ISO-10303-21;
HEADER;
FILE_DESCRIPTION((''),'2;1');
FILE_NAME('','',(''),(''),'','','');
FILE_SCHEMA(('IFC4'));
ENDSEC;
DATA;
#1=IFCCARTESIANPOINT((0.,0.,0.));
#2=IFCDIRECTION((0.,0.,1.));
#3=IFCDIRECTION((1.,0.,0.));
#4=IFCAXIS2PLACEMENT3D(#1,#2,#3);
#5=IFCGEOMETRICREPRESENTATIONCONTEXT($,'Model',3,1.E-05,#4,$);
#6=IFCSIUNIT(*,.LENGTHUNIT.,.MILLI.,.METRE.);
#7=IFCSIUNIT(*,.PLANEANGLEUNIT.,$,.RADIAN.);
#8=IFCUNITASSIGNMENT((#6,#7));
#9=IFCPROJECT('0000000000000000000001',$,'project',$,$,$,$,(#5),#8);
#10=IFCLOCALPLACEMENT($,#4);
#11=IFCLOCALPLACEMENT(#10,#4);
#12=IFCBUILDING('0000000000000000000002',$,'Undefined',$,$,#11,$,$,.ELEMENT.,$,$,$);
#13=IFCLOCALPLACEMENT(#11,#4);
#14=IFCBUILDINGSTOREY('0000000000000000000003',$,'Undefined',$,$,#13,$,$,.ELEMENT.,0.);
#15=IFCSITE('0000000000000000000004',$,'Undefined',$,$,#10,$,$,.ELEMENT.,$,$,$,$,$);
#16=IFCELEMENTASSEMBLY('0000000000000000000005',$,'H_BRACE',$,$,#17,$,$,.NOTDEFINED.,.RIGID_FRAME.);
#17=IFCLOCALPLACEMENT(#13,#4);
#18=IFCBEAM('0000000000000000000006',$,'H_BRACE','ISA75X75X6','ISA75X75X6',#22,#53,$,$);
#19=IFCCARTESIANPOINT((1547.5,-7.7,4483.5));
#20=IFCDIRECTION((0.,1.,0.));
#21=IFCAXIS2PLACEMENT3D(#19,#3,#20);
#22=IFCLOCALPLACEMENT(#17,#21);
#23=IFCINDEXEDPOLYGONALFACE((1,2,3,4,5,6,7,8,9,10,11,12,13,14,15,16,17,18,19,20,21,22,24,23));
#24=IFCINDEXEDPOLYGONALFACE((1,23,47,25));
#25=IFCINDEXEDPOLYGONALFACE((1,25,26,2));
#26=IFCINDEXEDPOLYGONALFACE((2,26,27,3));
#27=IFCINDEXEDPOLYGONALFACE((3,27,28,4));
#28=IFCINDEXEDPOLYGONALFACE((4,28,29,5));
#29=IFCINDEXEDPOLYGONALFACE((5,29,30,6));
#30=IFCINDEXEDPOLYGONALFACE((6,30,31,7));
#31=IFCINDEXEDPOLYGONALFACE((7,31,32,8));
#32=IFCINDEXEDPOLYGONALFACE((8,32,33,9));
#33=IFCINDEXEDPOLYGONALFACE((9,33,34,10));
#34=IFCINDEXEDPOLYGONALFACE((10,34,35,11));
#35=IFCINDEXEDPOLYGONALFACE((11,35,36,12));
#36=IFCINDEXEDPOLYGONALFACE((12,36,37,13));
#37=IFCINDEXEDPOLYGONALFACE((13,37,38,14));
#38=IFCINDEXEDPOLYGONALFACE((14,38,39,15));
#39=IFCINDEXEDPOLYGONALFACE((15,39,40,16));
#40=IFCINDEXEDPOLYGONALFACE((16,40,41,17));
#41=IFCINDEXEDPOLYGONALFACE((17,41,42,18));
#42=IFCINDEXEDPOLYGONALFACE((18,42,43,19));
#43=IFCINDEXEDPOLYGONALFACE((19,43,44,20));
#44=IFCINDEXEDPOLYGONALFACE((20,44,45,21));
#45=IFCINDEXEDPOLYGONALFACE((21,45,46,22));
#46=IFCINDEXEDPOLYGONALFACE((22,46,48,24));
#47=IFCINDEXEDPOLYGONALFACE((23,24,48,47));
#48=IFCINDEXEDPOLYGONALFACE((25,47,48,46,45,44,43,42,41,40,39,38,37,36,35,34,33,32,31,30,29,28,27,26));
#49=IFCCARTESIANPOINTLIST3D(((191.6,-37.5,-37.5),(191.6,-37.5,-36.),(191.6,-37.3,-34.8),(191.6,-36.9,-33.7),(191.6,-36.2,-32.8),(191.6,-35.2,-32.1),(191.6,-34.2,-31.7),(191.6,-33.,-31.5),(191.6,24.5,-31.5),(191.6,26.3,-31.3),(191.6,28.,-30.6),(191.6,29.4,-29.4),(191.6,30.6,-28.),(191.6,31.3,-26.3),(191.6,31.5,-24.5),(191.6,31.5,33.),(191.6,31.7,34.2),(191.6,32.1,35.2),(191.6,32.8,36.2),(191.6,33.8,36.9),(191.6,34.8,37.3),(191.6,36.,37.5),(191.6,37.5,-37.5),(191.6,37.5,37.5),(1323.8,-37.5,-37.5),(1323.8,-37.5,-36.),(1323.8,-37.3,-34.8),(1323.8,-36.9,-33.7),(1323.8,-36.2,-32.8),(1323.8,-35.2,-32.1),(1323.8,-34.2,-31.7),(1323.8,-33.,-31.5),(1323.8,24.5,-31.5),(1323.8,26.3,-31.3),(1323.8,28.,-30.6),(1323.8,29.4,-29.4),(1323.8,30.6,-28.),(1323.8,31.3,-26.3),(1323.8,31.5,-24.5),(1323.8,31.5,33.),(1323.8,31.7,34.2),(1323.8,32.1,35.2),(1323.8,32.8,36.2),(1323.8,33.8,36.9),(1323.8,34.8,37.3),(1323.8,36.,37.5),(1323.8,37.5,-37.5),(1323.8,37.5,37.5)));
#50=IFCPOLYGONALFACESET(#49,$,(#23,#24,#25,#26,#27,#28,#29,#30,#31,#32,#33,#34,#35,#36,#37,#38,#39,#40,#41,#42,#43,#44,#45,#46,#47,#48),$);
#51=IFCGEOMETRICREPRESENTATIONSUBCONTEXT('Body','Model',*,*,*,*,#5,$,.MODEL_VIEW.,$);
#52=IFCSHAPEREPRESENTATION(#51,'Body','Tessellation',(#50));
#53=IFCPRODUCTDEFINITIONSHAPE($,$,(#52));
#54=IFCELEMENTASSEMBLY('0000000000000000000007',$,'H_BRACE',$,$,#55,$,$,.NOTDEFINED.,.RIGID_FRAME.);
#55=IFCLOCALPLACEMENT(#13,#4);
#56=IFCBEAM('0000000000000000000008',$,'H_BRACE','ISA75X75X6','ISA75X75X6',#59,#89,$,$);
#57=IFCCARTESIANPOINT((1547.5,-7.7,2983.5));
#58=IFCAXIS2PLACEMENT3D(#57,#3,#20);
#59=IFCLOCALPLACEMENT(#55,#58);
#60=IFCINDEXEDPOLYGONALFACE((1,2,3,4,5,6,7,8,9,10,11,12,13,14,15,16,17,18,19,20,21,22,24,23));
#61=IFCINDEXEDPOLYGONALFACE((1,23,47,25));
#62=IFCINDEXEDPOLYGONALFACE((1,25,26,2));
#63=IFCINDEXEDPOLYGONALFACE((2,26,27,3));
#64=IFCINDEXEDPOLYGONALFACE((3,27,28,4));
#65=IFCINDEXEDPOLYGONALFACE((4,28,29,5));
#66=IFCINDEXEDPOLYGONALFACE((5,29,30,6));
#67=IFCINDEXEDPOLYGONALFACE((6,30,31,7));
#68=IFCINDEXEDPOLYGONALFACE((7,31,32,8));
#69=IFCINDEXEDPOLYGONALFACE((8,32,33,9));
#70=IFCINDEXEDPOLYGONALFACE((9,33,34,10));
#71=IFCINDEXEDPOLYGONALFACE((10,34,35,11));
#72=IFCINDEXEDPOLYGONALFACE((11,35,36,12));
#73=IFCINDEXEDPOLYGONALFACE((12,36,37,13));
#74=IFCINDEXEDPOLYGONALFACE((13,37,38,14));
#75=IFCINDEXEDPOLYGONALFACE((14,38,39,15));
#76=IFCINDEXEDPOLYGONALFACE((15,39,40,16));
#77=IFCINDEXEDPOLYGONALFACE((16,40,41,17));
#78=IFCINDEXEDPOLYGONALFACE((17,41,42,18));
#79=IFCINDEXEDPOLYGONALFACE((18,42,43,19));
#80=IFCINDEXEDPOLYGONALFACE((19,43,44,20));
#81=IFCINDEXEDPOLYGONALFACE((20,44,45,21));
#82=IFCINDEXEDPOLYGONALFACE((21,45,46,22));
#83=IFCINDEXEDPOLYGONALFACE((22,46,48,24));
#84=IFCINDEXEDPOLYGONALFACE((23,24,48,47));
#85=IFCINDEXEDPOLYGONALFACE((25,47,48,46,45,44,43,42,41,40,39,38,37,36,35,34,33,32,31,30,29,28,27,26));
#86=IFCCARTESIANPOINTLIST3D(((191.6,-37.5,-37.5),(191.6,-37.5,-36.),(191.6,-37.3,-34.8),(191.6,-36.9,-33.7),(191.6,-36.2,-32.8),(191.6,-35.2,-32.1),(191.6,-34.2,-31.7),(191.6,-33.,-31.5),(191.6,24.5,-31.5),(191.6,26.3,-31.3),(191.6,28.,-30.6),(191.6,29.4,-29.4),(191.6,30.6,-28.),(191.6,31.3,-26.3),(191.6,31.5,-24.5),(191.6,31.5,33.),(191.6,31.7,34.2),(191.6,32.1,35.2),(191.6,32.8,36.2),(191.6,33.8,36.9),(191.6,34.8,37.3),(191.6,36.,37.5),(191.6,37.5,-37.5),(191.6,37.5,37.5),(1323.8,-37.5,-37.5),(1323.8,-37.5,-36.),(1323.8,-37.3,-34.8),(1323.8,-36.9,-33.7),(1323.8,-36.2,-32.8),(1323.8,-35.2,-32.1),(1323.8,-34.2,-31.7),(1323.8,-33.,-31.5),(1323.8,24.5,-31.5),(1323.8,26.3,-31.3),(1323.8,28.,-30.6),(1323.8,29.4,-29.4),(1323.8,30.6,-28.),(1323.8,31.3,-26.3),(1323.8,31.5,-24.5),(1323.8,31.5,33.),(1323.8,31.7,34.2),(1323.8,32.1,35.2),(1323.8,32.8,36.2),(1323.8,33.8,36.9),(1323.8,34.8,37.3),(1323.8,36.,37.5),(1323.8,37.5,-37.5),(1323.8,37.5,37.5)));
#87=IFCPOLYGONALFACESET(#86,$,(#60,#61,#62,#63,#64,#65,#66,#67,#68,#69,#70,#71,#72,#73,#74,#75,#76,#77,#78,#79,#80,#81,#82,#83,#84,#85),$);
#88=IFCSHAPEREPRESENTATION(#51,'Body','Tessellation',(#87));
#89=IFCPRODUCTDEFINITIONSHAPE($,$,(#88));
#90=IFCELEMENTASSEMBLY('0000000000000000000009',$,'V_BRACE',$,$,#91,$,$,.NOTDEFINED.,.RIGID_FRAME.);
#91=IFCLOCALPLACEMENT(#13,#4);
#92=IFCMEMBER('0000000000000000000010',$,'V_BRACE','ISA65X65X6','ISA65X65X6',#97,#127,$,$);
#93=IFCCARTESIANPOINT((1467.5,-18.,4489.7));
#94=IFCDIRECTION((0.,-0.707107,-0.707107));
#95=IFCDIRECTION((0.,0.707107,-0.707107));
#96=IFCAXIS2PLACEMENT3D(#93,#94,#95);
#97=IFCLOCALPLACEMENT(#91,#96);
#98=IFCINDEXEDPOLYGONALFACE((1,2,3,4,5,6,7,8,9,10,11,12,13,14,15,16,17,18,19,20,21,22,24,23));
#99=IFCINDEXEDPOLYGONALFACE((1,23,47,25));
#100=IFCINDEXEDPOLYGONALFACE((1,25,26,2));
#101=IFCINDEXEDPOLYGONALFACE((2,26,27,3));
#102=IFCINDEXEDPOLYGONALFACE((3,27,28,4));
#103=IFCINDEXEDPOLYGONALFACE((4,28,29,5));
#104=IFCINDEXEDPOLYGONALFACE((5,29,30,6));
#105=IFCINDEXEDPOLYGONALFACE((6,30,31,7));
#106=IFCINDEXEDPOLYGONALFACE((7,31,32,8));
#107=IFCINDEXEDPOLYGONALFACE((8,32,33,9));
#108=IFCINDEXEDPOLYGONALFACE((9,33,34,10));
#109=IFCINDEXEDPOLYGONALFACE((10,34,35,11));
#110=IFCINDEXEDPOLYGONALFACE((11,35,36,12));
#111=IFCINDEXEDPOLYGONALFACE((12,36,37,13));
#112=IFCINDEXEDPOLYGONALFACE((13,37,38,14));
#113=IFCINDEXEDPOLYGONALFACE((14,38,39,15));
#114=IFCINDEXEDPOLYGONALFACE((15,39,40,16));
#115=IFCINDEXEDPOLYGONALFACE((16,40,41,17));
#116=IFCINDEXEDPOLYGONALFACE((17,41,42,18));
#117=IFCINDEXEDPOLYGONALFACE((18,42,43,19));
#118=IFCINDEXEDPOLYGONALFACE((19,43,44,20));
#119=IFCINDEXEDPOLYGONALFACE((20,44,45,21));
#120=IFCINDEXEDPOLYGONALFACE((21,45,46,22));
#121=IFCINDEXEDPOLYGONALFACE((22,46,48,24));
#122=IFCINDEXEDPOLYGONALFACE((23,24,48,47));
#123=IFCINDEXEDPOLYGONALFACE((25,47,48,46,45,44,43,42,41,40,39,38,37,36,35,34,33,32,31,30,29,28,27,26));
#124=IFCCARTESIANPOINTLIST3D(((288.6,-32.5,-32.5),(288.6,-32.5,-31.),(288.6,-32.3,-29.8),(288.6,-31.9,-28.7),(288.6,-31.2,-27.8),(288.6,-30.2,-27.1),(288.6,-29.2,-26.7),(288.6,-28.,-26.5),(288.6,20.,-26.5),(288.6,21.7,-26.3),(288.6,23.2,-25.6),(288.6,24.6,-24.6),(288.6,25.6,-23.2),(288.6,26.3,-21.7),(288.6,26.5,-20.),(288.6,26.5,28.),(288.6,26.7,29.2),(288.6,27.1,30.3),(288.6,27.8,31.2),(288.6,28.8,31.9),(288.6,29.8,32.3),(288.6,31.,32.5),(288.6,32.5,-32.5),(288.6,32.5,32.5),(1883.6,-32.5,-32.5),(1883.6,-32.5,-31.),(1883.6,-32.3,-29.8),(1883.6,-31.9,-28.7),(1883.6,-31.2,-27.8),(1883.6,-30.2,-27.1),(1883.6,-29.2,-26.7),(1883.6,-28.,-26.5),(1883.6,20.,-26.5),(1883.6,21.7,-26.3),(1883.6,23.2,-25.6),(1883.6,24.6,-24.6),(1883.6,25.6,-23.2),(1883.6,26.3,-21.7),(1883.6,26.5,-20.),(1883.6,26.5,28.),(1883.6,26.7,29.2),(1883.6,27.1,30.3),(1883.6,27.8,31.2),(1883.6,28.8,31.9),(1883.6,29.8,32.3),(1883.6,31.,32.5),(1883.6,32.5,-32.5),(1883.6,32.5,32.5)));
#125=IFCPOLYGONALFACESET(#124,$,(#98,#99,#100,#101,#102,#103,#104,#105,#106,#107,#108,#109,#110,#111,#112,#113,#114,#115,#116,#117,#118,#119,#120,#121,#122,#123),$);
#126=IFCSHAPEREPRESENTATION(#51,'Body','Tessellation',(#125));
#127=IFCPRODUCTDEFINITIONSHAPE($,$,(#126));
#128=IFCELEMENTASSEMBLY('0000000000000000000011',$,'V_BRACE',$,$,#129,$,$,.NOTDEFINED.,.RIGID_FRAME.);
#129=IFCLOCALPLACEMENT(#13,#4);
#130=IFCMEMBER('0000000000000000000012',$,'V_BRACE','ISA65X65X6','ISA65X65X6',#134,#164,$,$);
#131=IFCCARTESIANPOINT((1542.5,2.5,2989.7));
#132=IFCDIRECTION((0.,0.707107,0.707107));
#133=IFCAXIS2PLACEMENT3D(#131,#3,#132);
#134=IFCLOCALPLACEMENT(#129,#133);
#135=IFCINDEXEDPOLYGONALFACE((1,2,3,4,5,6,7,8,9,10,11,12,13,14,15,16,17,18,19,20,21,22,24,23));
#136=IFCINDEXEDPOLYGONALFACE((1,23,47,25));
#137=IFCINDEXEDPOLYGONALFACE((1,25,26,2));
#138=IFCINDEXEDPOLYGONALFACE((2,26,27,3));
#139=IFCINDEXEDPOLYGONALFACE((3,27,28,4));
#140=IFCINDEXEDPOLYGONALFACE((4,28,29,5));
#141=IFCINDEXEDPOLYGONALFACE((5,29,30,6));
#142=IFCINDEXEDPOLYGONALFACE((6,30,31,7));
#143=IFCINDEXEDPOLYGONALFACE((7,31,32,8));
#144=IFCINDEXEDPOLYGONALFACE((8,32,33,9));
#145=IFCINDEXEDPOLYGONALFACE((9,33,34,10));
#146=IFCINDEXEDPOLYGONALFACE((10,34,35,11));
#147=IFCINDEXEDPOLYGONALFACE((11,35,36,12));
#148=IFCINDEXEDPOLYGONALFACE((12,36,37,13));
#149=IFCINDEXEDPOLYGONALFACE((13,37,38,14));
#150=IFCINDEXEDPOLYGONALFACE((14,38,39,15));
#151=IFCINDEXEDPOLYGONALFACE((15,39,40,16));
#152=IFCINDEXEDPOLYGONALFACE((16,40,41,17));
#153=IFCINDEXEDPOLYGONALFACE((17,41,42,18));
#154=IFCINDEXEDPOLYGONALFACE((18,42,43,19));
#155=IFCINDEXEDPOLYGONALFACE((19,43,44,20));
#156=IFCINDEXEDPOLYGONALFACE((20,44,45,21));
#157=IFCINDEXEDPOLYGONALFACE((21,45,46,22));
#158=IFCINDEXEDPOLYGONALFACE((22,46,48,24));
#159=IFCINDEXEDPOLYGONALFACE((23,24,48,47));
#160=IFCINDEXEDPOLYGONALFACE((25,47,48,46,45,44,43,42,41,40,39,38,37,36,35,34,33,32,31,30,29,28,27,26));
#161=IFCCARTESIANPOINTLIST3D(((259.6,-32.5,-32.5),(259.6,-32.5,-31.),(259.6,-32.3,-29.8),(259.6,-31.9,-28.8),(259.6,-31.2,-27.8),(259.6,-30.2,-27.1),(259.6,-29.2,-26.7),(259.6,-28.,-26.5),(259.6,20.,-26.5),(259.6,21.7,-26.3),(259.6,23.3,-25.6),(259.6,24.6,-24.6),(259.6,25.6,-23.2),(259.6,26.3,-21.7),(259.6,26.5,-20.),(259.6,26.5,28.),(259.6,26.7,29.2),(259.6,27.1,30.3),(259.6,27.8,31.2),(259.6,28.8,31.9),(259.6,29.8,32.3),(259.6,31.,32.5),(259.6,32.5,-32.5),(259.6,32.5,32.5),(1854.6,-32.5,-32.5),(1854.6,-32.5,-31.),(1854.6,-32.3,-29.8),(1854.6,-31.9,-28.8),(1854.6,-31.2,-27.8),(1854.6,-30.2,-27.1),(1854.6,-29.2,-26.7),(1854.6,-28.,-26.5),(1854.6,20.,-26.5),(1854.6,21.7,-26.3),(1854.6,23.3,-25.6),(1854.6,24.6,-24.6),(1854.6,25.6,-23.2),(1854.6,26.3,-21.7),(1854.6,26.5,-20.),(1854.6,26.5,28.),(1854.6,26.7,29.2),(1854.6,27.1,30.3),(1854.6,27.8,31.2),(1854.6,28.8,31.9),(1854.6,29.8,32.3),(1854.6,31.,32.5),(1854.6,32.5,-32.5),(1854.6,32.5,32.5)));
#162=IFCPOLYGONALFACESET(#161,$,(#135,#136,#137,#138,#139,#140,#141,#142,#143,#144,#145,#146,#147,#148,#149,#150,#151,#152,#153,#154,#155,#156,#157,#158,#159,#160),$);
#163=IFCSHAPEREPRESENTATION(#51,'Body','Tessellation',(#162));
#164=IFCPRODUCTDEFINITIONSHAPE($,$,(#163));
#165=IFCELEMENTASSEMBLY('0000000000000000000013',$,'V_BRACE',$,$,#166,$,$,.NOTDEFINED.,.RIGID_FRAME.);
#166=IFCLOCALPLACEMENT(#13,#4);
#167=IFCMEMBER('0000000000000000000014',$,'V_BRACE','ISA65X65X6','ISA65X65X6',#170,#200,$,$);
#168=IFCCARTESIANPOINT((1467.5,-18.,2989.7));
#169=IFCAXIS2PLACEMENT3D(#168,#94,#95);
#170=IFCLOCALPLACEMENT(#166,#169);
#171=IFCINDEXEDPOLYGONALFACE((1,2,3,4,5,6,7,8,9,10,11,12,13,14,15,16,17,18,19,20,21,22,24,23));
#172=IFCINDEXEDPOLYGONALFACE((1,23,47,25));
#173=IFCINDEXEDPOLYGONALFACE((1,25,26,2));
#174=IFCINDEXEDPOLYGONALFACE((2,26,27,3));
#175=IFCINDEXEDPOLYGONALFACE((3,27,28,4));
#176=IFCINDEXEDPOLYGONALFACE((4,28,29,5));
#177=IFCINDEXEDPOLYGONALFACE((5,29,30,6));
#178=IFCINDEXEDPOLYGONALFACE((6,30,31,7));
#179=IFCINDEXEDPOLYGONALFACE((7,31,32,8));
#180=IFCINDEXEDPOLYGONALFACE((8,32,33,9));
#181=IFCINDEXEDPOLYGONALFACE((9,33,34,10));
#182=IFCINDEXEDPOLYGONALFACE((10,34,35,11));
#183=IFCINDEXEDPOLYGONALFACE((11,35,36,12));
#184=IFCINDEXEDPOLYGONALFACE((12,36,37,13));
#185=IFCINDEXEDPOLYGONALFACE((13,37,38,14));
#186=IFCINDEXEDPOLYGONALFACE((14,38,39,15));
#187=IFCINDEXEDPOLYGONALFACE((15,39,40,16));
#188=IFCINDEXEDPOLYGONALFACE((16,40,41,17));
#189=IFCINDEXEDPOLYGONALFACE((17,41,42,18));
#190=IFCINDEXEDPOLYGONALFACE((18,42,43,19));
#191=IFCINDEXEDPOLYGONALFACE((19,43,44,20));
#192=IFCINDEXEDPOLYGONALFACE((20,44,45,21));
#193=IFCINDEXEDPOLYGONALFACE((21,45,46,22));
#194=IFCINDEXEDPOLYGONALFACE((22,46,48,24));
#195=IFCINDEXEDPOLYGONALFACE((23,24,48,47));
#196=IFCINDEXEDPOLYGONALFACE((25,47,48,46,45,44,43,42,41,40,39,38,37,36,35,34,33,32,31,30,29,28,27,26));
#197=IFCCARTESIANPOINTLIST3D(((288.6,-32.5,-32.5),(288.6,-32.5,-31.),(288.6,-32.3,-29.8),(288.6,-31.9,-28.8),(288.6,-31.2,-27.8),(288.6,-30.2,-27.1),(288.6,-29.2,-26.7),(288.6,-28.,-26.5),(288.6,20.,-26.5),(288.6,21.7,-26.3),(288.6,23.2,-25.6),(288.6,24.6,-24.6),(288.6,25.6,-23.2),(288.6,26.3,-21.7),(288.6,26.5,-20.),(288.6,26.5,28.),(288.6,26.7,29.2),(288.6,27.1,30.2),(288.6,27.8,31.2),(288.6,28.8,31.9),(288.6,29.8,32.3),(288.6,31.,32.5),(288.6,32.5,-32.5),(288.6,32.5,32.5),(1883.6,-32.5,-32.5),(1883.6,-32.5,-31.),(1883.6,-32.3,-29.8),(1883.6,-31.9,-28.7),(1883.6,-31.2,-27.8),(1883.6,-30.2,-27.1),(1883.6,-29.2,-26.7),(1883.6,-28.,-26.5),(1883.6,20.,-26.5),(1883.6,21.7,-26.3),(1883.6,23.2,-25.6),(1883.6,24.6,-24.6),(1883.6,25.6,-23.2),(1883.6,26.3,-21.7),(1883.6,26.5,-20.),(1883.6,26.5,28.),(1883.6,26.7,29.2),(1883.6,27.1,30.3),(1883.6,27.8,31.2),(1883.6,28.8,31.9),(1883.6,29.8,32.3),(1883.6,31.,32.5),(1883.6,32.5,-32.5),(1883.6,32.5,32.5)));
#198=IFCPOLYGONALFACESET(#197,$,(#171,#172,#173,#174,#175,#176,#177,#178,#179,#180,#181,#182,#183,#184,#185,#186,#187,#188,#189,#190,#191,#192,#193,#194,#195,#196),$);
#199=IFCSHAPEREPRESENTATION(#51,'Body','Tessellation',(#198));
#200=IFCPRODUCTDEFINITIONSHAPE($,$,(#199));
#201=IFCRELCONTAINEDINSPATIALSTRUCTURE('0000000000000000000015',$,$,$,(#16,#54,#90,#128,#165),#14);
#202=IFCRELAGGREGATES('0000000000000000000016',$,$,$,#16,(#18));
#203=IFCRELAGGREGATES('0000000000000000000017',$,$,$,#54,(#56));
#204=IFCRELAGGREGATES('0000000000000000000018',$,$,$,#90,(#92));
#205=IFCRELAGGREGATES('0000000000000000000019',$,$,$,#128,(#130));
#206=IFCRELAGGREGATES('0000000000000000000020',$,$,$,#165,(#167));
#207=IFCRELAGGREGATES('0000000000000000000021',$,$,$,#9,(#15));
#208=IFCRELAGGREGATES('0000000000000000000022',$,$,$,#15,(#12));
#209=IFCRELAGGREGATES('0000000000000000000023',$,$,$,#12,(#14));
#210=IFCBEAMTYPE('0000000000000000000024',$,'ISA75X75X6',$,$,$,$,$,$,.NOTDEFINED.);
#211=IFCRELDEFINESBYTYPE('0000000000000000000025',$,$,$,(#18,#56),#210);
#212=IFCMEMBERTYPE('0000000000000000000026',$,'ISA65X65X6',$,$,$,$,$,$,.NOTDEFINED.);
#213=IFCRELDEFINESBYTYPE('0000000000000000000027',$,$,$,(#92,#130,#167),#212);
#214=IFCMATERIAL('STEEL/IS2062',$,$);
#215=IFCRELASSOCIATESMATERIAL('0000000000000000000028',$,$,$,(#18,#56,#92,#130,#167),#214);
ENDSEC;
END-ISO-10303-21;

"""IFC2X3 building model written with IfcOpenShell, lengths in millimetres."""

from ifc_helpers import new_model, si_unit, frame, origin_with_axes, origin_2d_with_axis, place, context, subcontext, project, spatial, l_section, extrude, clip, halfspace, material, type_object, element, aggregate, save


model = new_model("IFC2X3")

# Units and contexts
model_context = context("Model", 3, precision=1e-05, world=origin_with_axes())
body_context = subcontext(model_context, "Body", "Model", "MODEL_VIEW")
ifc_project = project(units=[si_unit("LENGTHUNIT", "METRE", prefix="MILLI"), si_unit("PLANEANGLEUNIT", "RADIAN")], contexts=[model_context])

# Site, building, storey
site_placement = place(None, origin_with_axes())
site = spatial("IfcSite", under=ifc_project, at=site_placement, Name="Undefined", CompositionType="ELEMENT")
building_placement = place(site_placement, origin_with_axes())
building = spatial("IfcBuilding", under=site, at=building_placement, Name="Undefined", CompositionType="ELEMENT")
storey_placement = place(building_placement, origin_with_axes())
storey = spatial("IfcBuildingStorey", under=building, at=storey_placement, Name="Undefined", CompositionType="ELEMENT", Elevation=0.0)

# Shared definitions
ifc_material = material(Name="STEEL/IS2062")

# Element assemblies, beams
assembly_1_placement = place(storey_placement, origin_with_axes())
assembly_1 = element("IfcElementAssembly", 1, at=assembly_1_placement, inside=storey, Name="H_BRACE", AssemblyPlace="NOTDEFINED", PredefinedType="RIGID_FRAME")
beam_type_1 = type_object("IfcBeamType", Name="ISA75X75X6", PredefinedType="NOTDEFINED")
beam_1_placement = place(assembly_1_placement, frame((1547.5, -7.7, 4483.5), z_axis=(1.0, 0.0, 0.0), x_axis=(0.0, 1.0, 0.0)))
beam_1 = element("IfcBeam", 2, at=beam_1_placement, type_object=beam_type_1, material=ifc_material, Name="H_BRACE", Description="ISA75X75X6", ObjectType="ISA75X75X6", context=body_context, shape_type="Clipping", body=[
    clip(clip(extrude(l_section(Depth=75.0, Width=75.0, Thickness=6.0, FilletRadius=7.0, EdgeRadius=4.5, at=origin_2d_with_axis()), frame((1500.0, 0.0, 0.0), z_axis=(-1.0, 0.0, 0.0), x_axis=(0.0, -1.0, 0.0)), (0.0, 0.0, 1.0), 1500.0), halfspace(frame((1323.8, 0.0, -47.5), z_axis=(-1.0, 0.0, 0.0), x_axis=(0.0, 1.0, 0.0)), True)), halfspace(frame((191.6, 0.0, -47.5), z_axis=(1.0, 0.0, 0.0), x_axis=(0.0, -1.0, 0.0)), True)),
])
aggregate(assembly_1, [beam_1])
assembly_2_placement = place(storey_placement, origin_with_axes())
assembly_2 = element("IfcElementAssembly", 3, at=assembly_2_placement, inside=storey, Name="H_BRACE", AssemblyPlace="NOTDEFINED", PredefinedType="RIGID_FRAME")
beam_2_placement = place(assembly_2_placement, frame((1547.5, -7.7, 2983.5), z_axis=(1.0, 0.0, 0.0), x_axis=(0.0, 1.0, 0.0)))
beam_2 = element("IfcBeam", 4, at=beam_2_placement, type_object=beam_type_1, material=ifc_material, Name="H_BRACE", Description="ISA75X75X6", ObjectType="ISA75X75X6", context=body_context, shape_type="Clipping", body=[
    clip(clip(extrude(l_section(Depth=75.0, Width=75.0, Thickness=6.0, FilletRadius=7.0, EdgeRadius=4.5, at=origin_2d_with_axis()), frame((1500.0, 0.0, 0.0), z_axis=(-1.0, 0.0, 0.0), x_axis=(0.0, -1.0, 0.0)), (0.0, 0.0, 1.0), 1500.0), halfspace(frame((1323.8, 0.0, -47.5), z_axis=(-1.0, 0.0, 0.0), x_axis=(0.0, 1.0, 0.0)), True)), halfspace(frame((191.6, 0.0, -47.5), z_axis=(1.0, 0.0, 0.0), x_axis=(0.0, -1.0, 0.0)), True)),
])
aggregate(assembly_2, [beam_2])

# Element assemblies, members
assembly_3_placement = place(storey_placement, origin_with_axes())
assembly_3 = element("IfcElementAssembly", 5, at=assembly_3_placement, inside=storey, Name="V_BRACE", AssemblyPlace="NOTDEFINED", PredefinedType="RIGID_FRAME")
member_type = type_object("IfcMemberType", Name="ISA65X65X6", PredefinedType="NOTDEFINED")
member_1_placement = place(assembly_3_placement, frame((1467.5, -18.0, 4489.7), z_axis=(0.0, -0.707107, -0.707107), x_axis=(0.0, 0.707107, -0.707107)))
member_1 = element("IfcMember", 6, at=member_1_placement, type_object=member_type, material=ifc_material, Name="V_BRACE", Description="ISA65X65X6", ObjectType="ISA65X65X6", context=body_context, shape_type="Clipping", body=[
    clip(clip(extrude(l_section(Depth=65.0, Width=65.0, Thickness=6.0, FilletRadius=6.5, EdgeRadius=4.5, at=origin_2d_with_axis()), frame((2121.3, 0.0, 0.0), z_axis=(-1.0, 0.0, 0.0), x_axis=(0.0, -1.0, 0.0)), (0.0, 0.0, 1.0), 2121.3), halfspace(frame((1883.6, 32.5, 0.0), z_axis=(-1.0, 0.0, 0.0), x_axis=(0.0, 0.0, -1.0)), True)), halfspace(frame((288.6, 32.5, 0.0), z_axis=(1.0, 0.0, 0.0), x_axis=(0.0, 0.0, 1.0)), True)),
])
aggregate(assembly_3, [member_1])
assembly_4_placement = place(storey_placement, origin_with_axes())
assembly_4 = element("IfcElementAssembly", 7, at=assembly_4_placement, inside=storey, Name="V_BRACE", AssemblyPlace="NOTDEFINED", PredefinedType="RIGID_FRAME")
member_2_placement = place(assembly_4_placement, frame((1542.5, 2.5, 2989.7), z_axis=(1.0, 0.0, 0.0), x_axis=(0.0, 0.707107, 0.707107)))
member_2 = element("IfcMember", 8, at=member_2_placement, type_object=member_type, material=ifc_material, Name="V_BRACE", Description="ISA65X65X6", ObjectType="ISA65X65X6", context=body_context, shape_type="Clipping", body=[
    clip(clip(extrude(l_section(Depth=65.0, Width=65.0, Thickness=6.0, FilletRadius=6.5, EdgeRadius=4.5, at=origin_2d_with_axis()), frame((2121.3, 0.0, 0.0), z_axis=(-1.0, 0.0, 0.0), x_axis=(0.0, -1.0, 0.0)), (0.0, 0.0, 1.0), 2121.3), halfspace(frame((1854.6, 0.0, -42.5), z_axis=(-1.0, 0.0, 0.0), x_axis=(0.0, 1.0, 0.0)), True)), halfspace(frame((259.6, 0.0, -42.5), z_axis=(1.0, 0.0, 0.0), x_axis=(0.0, -1.0, 0.0)), True)),
])
aggregate(assembly_4, [member_2])
assembly_5_placement = place(storey_placement, origin_with_axes())
assembly_5 = element("IfcElementAssembly", 9, at=assembly_5_placement, inside=storey, Name="V_BRACE", AssemblyPlace="NOTDEFINED", PredefinedType="RIGID_FRAME")
member_3_placement = place(assembly_5_placement, frame((1467.5, -18.0, 2989.7), z_axis=(0.0, -0.707107, -0.707107), x_axis=(0.0, 0.707107, -0.707107)))
member_3 = element("IfcMember", 10, at=member_3_placement, type_object=member_type, material=ifc_material, Name="V_BRACE", Description="ISA65X65X6", ObjectType="ISA65X65X6", context=body_context, shape_type="Clipping", body=[
    clip(clip(extrude(l_section(Depth=65.0, Width=65.0, Thickness=6.0, FilletRadius=6.5, EdgeRadius=4.5, at=origin_2d_with_axis()), frame((2121.3, 0.0, 0.0), z_axis=(-1.0, 0.0, 0.0), x_axis=(0.0, -1.0, 0.0)), (0.0, 0.0, 1.0), 2121.3), halfspace(frame((1883.6, 32.5, 0.0), z_axis=(-1.0, 0.0, 0.0), x_axis=(0.0, 0.0, -1.0)), True)), halfspace(frame((288.6, 32.5, 0.0), z_axis=(1.0, 0.0, 0.0), x_axis=(0.0, 0.0, 1.0)), True)),
])
aggregate(assembly_5, [member_3])

save(model, "model.ifc")
